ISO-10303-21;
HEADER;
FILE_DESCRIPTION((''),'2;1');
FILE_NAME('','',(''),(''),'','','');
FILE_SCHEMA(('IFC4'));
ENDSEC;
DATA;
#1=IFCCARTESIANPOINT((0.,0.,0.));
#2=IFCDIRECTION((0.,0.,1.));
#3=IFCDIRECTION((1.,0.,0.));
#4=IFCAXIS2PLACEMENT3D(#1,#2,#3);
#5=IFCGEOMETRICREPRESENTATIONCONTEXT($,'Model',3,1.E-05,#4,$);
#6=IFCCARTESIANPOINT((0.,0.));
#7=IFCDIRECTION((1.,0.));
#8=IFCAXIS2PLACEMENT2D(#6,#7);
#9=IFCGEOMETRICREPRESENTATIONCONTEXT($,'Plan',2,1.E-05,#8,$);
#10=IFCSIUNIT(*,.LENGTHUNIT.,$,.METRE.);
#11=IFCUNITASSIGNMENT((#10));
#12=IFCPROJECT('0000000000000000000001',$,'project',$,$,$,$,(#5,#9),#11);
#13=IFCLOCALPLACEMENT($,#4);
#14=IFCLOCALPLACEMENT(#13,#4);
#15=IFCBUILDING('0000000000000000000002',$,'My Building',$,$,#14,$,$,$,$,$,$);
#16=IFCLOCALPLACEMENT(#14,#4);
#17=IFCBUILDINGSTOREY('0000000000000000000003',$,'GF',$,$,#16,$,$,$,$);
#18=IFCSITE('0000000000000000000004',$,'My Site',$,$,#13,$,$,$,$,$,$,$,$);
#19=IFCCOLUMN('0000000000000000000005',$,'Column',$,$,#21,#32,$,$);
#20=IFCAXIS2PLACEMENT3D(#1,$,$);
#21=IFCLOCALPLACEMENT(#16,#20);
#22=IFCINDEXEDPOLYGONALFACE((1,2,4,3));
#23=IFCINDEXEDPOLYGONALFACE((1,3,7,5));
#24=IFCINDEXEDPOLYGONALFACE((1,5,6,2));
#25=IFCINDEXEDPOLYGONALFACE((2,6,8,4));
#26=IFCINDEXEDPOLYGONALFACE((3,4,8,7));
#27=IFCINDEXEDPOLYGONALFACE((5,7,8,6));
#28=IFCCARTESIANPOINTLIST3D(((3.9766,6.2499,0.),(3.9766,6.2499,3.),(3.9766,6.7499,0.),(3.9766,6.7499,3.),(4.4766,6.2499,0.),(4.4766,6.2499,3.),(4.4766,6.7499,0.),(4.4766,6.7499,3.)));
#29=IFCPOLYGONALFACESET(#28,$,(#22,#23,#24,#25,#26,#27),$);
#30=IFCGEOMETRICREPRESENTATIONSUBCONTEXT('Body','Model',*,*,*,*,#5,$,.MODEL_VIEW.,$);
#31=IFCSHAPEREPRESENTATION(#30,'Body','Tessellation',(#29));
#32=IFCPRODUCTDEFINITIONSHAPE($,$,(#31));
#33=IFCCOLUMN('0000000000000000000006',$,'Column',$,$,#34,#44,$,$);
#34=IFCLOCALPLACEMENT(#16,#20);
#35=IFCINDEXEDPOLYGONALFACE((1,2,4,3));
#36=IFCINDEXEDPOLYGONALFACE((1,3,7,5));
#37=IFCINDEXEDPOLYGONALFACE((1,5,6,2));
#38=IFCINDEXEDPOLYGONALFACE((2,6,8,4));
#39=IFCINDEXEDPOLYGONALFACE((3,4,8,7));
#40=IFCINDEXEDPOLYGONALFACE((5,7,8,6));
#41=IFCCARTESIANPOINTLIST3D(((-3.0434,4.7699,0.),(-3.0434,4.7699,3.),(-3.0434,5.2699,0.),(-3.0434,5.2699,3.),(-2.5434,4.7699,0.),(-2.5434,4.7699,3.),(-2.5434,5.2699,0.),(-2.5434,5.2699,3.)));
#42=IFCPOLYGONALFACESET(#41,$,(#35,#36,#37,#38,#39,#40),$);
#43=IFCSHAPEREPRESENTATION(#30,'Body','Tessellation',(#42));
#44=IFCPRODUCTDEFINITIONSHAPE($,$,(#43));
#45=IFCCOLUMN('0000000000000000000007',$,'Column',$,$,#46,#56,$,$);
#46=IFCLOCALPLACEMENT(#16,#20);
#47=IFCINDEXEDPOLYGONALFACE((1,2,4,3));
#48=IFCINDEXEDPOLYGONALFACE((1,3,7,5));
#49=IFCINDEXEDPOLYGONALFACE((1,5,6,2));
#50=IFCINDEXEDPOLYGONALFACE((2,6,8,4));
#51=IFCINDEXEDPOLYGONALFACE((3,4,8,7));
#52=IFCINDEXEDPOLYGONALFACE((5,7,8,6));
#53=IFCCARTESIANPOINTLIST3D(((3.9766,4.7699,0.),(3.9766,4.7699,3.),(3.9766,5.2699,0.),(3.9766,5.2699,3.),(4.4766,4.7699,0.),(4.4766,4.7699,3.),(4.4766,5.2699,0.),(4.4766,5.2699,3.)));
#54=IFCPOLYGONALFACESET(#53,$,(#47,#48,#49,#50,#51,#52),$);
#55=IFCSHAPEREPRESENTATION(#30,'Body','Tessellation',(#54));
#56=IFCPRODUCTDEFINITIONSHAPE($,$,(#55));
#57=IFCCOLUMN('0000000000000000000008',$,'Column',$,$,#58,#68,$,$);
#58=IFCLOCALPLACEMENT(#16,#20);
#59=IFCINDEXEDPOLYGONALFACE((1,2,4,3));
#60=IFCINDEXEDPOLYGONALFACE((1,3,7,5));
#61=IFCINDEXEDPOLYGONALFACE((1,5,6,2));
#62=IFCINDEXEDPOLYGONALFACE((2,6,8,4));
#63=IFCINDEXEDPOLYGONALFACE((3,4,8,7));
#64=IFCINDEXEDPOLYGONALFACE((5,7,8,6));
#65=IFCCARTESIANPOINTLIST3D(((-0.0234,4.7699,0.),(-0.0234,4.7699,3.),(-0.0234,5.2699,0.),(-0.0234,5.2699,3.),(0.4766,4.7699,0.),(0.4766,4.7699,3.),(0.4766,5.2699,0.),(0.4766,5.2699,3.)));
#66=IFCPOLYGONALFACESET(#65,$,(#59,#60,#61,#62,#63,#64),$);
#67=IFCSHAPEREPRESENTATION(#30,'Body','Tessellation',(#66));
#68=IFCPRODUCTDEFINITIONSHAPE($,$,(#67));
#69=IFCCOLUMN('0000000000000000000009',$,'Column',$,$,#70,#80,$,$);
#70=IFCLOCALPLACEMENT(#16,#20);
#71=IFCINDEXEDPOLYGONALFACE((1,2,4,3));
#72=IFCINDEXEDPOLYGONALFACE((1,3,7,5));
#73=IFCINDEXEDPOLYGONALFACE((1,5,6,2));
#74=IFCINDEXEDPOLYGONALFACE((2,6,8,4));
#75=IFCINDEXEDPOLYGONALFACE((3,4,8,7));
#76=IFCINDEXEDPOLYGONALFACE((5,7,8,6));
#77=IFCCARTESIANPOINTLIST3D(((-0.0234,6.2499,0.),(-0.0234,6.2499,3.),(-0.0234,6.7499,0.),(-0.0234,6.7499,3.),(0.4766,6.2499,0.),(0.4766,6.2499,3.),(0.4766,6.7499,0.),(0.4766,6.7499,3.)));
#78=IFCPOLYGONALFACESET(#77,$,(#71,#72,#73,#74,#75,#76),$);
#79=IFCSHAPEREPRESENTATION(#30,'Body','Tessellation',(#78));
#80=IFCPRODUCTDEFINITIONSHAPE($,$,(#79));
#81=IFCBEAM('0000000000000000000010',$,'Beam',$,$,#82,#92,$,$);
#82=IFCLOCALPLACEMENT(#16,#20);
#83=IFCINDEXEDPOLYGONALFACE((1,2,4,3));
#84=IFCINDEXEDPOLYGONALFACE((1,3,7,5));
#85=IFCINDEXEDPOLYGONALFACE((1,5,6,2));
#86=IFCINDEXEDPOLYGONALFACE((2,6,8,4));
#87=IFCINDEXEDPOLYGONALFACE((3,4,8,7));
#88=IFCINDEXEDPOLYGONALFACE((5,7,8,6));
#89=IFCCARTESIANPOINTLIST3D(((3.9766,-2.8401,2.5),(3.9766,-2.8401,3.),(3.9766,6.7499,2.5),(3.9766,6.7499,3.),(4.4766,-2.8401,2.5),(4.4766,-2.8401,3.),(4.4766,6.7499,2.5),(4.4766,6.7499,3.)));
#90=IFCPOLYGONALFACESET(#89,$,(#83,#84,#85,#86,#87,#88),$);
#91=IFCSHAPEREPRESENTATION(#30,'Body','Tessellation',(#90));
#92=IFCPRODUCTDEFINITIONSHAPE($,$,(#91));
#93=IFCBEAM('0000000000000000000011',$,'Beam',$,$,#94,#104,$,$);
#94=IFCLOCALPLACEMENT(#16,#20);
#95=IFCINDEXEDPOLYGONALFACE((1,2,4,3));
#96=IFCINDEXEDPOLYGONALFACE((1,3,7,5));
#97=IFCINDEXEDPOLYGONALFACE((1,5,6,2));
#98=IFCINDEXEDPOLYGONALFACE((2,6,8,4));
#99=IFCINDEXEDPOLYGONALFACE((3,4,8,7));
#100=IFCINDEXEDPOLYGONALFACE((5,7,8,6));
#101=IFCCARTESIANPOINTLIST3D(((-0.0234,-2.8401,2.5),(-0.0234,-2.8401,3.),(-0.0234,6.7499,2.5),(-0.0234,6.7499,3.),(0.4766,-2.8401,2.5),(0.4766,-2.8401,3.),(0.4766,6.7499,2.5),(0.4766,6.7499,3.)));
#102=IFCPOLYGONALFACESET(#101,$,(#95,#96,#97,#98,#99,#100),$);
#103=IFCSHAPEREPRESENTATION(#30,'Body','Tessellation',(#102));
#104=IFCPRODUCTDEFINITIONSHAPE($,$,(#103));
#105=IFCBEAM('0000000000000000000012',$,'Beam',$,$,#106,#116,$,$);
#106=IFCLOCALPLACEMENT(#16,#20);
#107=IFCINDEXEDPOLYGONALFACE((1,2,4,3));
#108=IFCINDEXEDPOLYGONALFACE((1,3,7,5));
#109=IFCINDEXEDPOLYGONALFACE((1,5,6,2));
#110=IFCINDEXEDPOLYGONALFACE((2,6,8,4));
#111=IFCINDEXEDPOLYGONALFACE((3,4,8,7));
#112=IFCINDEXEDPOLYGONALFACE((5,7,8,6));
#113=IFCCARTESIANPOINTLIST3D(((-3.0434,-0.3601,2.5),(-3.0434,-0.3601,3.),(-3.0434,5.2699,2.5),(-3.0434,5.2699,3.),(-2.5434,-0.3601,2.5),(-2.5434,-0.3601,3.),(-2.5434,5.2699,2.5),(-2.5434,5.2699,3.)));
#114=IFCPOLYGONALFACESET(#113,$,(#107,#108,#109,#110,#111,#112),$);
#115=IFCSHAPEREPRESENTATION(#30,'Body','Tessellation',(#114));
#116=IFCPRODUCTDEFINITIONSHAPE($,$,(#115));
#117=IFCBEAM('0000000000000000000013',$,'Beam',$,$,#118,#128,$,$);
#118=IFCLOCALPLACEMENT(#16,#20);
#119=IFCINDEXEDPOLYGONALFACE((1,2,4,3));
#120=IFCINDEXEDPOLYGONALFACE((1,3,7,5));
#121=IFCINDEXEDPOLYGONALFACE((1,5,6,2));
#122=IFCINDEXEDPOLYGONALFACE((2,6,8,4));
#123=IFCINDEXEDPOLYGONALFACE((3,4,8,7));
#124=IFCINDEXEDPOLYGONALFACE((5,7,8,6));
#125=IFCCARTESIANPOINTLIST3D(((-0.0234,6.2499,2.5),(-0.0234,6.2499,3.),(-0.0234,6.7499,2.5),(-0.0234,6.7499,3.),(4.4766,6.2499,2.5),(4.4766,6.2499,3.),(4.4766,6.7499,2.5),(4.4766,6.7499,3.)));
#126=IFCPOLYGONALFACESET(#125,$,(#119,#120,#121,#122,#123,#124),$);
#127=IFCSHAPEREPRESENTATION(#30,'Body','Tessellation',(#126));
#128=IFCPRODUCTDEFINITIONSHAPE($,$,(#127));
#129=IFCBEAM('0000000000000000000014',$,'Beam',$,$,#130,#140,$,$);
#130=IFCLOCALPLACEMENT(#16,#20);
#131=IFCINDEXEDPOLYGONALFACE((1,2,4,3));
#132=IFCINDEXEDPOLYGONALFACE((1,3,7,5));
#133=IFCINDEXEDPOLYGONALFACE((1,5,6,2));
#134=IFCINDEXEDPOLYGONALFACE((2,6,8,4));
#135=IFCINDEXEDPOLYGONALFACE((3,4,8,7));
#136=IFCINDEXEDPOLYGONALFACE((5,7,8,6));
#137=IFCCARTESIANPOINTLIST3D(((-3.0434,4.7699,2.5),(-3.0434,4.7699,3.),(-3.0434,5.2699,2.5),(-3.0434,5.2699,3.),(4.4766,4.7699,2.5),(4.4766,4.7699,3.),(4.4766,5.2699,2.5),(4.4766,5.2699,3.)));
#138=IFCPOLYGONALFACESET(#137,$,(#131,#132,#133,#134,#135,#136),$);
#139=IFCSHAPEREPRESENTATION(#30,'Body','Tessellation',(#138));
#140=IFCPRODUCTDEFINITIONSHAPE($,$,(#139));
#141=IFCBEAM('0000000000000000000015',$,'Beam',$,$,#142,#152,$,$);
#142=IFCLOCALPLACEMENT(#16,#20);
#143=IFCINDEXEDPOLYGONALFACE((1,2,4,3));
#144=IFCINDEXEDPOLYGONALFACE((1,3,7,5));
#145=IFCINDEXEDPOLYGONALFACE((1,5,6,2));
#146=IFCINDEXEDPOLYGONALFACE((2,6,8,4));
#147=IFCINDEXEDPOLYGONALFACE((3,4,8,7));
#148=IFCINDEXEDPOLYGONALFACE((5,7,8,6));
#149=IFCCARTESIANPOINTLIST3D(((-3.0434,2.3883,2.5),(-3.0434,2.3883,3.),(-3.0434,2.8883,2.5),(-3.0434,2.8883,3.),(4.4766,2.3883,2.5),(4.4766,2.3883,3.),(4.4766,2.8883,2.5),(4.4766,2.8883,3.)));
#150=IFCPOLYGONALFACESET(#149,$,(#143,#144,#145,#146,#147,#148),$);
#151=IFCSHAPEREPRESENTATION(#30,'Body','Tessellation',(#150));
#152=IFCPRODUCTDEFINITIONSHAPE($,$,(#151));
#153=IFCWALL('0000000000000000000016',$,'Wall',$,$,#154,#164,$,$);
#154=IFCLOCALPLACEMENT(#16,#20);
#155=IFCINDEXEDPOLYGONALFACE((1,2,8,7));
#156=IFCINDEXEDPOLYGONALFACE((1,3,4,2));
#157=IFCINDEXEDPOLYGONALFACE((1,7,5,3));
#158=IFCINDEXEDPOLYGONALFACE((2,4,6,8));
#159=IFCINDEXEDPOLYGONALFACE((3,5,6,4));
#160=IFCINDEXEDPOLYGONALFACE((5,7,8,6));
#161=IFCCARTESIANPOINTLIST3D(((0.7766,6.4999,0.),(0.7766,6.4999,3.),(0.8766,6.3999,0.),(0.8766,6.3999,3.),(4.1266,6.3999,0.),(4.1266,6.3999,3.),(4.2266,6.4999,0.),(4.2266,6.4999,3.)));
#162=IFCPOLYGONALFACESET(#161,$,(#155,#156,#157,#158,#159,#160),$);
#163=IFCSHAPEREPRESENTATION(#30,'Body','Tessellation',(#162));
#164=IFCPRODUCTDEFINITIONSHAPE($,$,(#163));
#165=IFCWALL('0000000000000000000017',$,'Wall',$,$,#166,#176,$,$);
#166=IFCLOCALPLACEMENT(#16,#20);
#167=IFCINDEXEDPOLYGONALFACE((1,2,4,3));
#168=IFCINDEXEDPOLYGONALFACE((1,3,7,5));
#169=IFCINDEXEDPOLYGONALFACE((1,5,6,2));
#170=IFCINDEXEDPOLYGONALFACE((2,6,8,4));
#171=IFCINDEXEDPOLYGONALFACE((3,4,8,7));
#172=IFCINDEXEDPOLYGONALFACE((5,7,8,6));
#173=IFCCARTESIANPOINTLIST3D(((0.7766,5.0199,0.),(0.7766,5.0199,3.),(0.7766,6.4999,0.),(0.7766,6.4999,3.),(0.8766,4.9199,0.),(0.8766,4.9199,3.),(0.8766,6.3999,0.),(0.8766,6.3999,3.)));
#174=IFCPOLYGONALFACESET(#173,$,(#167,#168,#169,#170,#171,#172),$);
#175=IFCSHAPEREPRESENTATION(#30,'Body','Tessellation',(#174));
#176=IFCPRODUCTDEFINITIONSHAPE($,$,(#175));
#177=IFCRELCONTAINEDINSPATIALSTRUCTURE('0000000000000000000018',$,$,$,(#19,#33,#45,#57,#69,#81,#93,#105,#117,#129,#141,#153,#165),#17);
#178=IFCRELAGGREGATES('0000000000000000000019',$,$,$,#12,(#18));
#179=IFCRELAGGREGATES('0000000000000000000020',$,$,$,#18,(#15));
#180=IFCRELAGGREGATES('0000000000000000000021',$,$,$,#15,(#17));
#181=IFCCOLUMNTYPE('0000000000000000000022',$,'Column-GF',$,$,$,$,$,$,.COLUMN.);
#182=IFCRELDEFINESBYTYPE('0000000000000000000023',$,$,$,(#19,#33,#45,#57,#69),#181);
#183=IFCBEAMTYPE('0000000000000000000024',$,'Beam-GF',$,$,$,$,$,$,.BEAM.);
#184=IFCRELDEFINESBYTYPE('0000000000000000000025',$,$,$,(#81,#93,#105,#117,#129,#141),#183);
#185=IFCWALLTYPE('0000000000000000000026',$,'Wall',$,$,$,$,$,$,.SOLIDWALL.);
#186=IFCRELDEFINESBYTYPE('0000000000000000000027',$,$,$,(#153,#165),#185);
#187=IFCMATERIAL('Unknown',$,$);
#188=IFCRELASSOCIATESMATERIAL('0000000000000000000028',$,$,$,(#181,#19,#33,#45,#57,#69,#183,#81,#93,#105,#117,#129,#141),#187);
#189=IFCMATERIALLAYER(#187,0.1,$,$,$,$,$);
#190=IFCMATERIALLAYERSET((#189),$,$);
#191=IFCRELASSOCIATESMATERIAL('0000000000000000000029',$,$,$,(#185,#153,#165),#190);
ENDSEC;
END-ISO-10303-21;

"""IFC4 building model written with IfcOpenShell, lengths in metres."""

from ifc_helpers import new_model, si_unit, frame, origin_with_axes, origin_2d_with_axis, place, context, subcontext, project, spatial, line, indexed_curve, rectangle, outline, extrude, material, layer, layer_set, layer_usage, material_profile, profile_set, profile_usage, type_object, element, save


model = new_model("IFC4")

# Units and contexts
model_context = context("Model", 3, precision=1e-05, world=origin_with_axes())
plan_context = context("Plan", 2, precision=1e-05, world=origin_2d_with_axis())
body_context_1 = subcontext(model_context, "Body", "Model", "MODEL_VIEW")
ifc_project = project(units=[si_unit("LENGTHUNIT", "METRE")], contexts=[model_context, plan_context])

# Site, building, storey
site_placement = place(None, origin_with_axes())
site = spatial("IfcSite", under=ifc_project, at=site_placement, Name="My Site")
building_placement = place(site_placement, origin_with_axes())
building = spatial("IfcBuilding", under=site, at=building_placement, Name="My Building")
storey_placement = place(building_placement, origin_with_axes())
storey = spatial("IfcBuildingStorey", under=building, at=storey_placement, Name="GF")

# Columns
ifc_material_1 = material(Name="Unknown")
ifc_material_profile_1 = material_profile(ifc_material_1, rectangle(XDim=0.5, YDim=0.5))
ifc_profile_set_1 = profile_set([ifc_material_profile_1])
ifc_profile_usage_1 = profile_usage(ifc_profile_set_1, cardinal=5)
column_type = type_object("IfcColumnType", Name="Column-GF", PredefinedType="COLUMN", material=ifc_profile_set_1)
column_1_placement = place(storey_placement, frame((4.2266, 6.4999, 0.0), z_axis=(0.0, 0.0, 1.0), x_axis=(1.0, 0.0, 0.0)))
element("IfcColumn", 1, at=column_1_placement, inside=storey, type_object=column_type, material=ifc_profile_usage_1, Name="Column", context=body_context_1, shape_type="SweptSolid", body=[
    extrude(rectangle(XDim=0.5, YDim=0.5), origin_with_axes(), (0.0, 0.0, 1.0), 3.0),
])
ifc_profile_usage_2 = profile_usage(ifc_profile_set_1, cardinal=5)
column_2_placement = place(storey_placement, frame((-2.7934, 5.0199, 0.0), z_axis=(0.0, 0.0, 1.0), x_axis=(1.0, 0.0, 0.0)))
element("IfcColumn", 2, at=column_2_placement, inside=storey, type_object=column_type, material=ifc_profile_usage_2, Name="Column", context=body_context_1, shape_type="SweptSolid", body=[
    extrude(rectangle(XDim=0.5, YDim=0.5), origin_with_axes(), (0.0, 0.0, 1.0), 3.0),
])
ifc_profile_usage_3 = profile_usage(ifc_profile_set_1, cardinal=5)
column_3_placement = place(storey_placement, frame((4.2266, 5.0199, 0.0), z_axis=(0.0, 0.0, 1.0), x_axis=(1.0, 0.0, 0.0)))
element("IfcColumn", 3, at=column_3_placement, inside=storey, type_object=column_type, material=ifc_profile_usage_3, Name="Column", context=body_context_1, shape_type="SweptSolid", body=[
    extrude(rectangle(XDim=0.5, YDim=0.5), origin_with_axes(), (0.0, 0.0, 1.0), 3.0),
])
ifc_profile_usage_4 = profile_usage(ifc_profile_set_1, cardinal=5)
column_4_placement = place(storey_placement, frame((0.2266, 5.0199, 0.0), z_axis=(0.0, 0.0, 1.0), x_axis=(1.0, 0.0, 0.0)))
element("IfcColumn", 4, at=column_4_placement, inside=storey, type_object=column_type, material=ifc_profile_usage_4, Name="Column", context=body_context_1, shape_type="SweptSolid", body=[
    extrude(rectangle(XDim=0.5, YDim=0.5), origin_with_axes(), (0.0, 0.0, 1.0), 3.0),
])
ifc_profile_usage_5 = profile_usage(ifc_profile_set_1, cardinal=5)
column_5_placement = place(storey_placement, frame((0.2266, 6.4999, 0.0), z_axis=(0.0, 0.0, 1.0), x_axis=(1.0, 0.0, 0.0)))
element("IfcColumn", 5, at=column_5_placement, inside=storey, type_object=column_type, material=ifc_profile_usage_5, Name="Column", context=body_context_1, shape_type="SweptSolid", body=[
    extrude(rectangle(XDim=0.5, YDim=0.5), origin_with_axes(), (0.0, 0.0, 1.0), 3.0),
])

# Beams
ifc_material_profile_2 = material_profile(ifc_material_1, rectangle(XDim=0.5, YDim=0.5))
ifc_profile_set_2 = profile_set([ifc_material_profile_2])
ifc_profile_usage_6 = profile_usage(ifc_profile_set_2, cardinal=7)
beam_type = type_object("IfcBeamType", Name="Beam-GF", PredefinedType="BEAM", material=ifc_profile_set_2)
beam_1_placement = place(storey_placement, frame((4.4766, 6.7499, 3.0), z_axis=(0.0, -1.0, 0.0), x_axis=(1.0, 0.0, 0.0)))
element("IfcBeam", 6, at=beam_1_placement, inside=storey, type_object=beam_type, material=ifc_profile_usage_6, Name="Beam", context=body_context_1, shape_type="SweptSolid", body=[
    extrude(rectangle(XDim=0.5, YDim=0.5), frame((-0.25, -0.25, 0.0), z_axis=(0.0, 0.0, 1.0), x_axis=(1.0, 0.0, 0.0)), (0.0, 0.0, 1.0), 9.59),
])
ifc_profile_usage_7 = profile_usage(ifc_profile_set_2, cardinal=7)
beam_2_placement = place(storey_placement, frame((0.4766, 6.7499, 3.0), z_axis=(0.0, -1.0, 0.0), x_axis=(1.0, 0.0, 0.0)))
element("IfcBeam", 7, at=beam_2_placement, inside=storey, type_object=beam_type, material=ifc_profile_usage_7, Name="Beam", context=body_context_1, shape_type="SweptSolid", body=[
    extrude(rectangle(XDim=0.5, YDim=0.5), frame((-0.25, -0.25, 0.0), z_axis=(0.0, 0.0, 1.0), x_axis=(1.0, 0.0, 0.0)), (0.0, 0.0, 1.0), 9.59),
])
ifc_profile_usage_8 = profile_usage(ifc_profile_set_2, cardinal=7)
beam_3_placement = place(storey_placement, frame((-2.5434, 5.2699, 3.0), z_axis=(0.0, -1.0, 0.0), x_axis=(1.0, 0.0, 0.0)))
element("IfcBeam", 8, at=beam_3_placement, inside=storey, type_object=beam_type, material=ifc_profile_usage_8, Name="Beam", context=body_context_1, shape_type="SweptSolid", body=[
    extrude(rectangle(XDim=0.5, YDim=0.5), frame((-0.25, -0.25, 0.0), z_axis=(0.0, 0.0, 1.0), x_axis=(1.0, 0.0, 0.0)), (0.0, 0.0, 1.0), 5.63),
])
ifc_profile_usage_9 = profile_usage(ifc_profile_set_2, cardinal=7)
beam_4_placement = place(storey_placement, frame((-0.0234, 6.7499, 3.0), z_axis=(1.0, -0.000001, 0.000001), x_axis=(0.000001, 1.0, 0.0)))
element("IfcBeam", 9, at=beam_4_placement, inside=storey, type_object=beam_type, material=ifc_profile_usage_9, Name="Beam", context=body_context_1, shape_type="SweptSolid", body=[
    extrude(rectangle(XDim=0.5, YDim=0.5), frame((-0.25, -0.25, 0.0), z_axis=(0.0, 0.0, 1.0), x_axis=(1.0, 0.0, 0.0)), (0.0, 0.0, 1.0), 4.5),
])
ifc_profile_usage_10 = profile_usage(ifc_profile_set_2, cardinal=7)
beam_5_placement = place(storey_placement, frame((-3.0434, 5.2699, 3.0), z_axis=(1.0, 0.0, 0.0), x_axis=(0.0, 1.0, 0.0)))
element("IfcBeam", 10, at=beam_5_placement, inside=storey, type_object=beam_type, material=ifc_profile_usage_10, Name="Beam", context=body_context_1, shape_type="SweptSolid", body=[
    extrude(rectangle(XDim=0.5, YDim=0.5), frame((-0.25, -0.25, 0.0), z_axis=(0.0, 0.0, 1.0), x_axis=(1.0, 0.0, 0.0)), (0.0, 0.0, 1.0), 7.52),
])
ifc_profile_usage_11 = profile_usage(ifc_profile_set_2, cardinal=7)
beam_6_placement = place(storey_placement, frame((-3.0434, 2.8883, 3.0), z_axis=(1.0, 0.0, 0.0), x_axis=(0.0, 1.0, 0.0)))
element("IfcBeam", 11, at=beam_6_placement, inside=storey, type_object=beam_type, material=ifc_profile_usage_11, Name="Beam", context=body_context_1, shape_type="SweptSolid", body=[
    extrude(rectangle(XDim=0.5, YDim=0.5), frame((-0.25, -0.25, 0.0), z_axis=(0.0, 0.0, 1.0), x_axis=(1.0, 0.0, 0.0)), (0.0, 0.0, 1.0), 7.52),
])

# Walls
ifc_layer_1 = layer(ifc_material_1, 0.1)
ifc_layer_set_1 = layer_set([ifc_layer_1])
ifc_layer_usage_1 = layer_usage(ifc_layer_set_1, "AXIS2", "POSITIVE", 0.0)
wall_type = type_object("IfcWallType", Name="Wall", PredefinedType="SOLIDWALL", material=ifc_layer_set_1)
wall_1_placement = place(storey_placement, frame((4.2266, 6.4999, 0.0), z_axis=(0.0, 0.0, 1.0), x_axis=(-1.0, 0.0, 0.0)))
element("IfcWall", 12, at=wall_1_placement, inside=storey, type_object=wall_type, material=ifc_layer_usage_1, Name="Wall", context=body_context_1, shape_type="SweptSolid", body=[
    extrude(outline(indexed_curve([(0.0, 0.0), (0.1, 0.1), (3.35, 0.1), (3.45, 0.0)], segments=[line(1, 2, 3, 4, 1)])), origin_with_axes(), (0.0, 0.0, 1.0), 3.0),
])
ifc_layer_usage_2 = layer_usage(ifc_layer_set_1, "AXIS2", "POSITIVE", 0.0)
wall_2_placement = place(storey_placement, frame((0.7766, 6.4999, 0.0), z_axis=(0.0, 0.0, 1.0), x_axis=(0.0, -1.0, 0.0)))
element("IfcWall", 13, at=wall_2_placement, inside=storey, type_object=wall_type, material=ifc_layer_usage_2, Name="Wall", context=body_context_1, shape_type="SweptSolid", body=[
    extrude(outline(indexed_curve([(0.0, 0.0), (0.1, 0.1), (1.58, 0.1), (1.48, 0.0)], segments=[line(1, 2, 3, 4, 1)])), origin_with_axes(), (0.0, 0.0, 1.0), 3.0),
])

save(model, "model.ifc")
